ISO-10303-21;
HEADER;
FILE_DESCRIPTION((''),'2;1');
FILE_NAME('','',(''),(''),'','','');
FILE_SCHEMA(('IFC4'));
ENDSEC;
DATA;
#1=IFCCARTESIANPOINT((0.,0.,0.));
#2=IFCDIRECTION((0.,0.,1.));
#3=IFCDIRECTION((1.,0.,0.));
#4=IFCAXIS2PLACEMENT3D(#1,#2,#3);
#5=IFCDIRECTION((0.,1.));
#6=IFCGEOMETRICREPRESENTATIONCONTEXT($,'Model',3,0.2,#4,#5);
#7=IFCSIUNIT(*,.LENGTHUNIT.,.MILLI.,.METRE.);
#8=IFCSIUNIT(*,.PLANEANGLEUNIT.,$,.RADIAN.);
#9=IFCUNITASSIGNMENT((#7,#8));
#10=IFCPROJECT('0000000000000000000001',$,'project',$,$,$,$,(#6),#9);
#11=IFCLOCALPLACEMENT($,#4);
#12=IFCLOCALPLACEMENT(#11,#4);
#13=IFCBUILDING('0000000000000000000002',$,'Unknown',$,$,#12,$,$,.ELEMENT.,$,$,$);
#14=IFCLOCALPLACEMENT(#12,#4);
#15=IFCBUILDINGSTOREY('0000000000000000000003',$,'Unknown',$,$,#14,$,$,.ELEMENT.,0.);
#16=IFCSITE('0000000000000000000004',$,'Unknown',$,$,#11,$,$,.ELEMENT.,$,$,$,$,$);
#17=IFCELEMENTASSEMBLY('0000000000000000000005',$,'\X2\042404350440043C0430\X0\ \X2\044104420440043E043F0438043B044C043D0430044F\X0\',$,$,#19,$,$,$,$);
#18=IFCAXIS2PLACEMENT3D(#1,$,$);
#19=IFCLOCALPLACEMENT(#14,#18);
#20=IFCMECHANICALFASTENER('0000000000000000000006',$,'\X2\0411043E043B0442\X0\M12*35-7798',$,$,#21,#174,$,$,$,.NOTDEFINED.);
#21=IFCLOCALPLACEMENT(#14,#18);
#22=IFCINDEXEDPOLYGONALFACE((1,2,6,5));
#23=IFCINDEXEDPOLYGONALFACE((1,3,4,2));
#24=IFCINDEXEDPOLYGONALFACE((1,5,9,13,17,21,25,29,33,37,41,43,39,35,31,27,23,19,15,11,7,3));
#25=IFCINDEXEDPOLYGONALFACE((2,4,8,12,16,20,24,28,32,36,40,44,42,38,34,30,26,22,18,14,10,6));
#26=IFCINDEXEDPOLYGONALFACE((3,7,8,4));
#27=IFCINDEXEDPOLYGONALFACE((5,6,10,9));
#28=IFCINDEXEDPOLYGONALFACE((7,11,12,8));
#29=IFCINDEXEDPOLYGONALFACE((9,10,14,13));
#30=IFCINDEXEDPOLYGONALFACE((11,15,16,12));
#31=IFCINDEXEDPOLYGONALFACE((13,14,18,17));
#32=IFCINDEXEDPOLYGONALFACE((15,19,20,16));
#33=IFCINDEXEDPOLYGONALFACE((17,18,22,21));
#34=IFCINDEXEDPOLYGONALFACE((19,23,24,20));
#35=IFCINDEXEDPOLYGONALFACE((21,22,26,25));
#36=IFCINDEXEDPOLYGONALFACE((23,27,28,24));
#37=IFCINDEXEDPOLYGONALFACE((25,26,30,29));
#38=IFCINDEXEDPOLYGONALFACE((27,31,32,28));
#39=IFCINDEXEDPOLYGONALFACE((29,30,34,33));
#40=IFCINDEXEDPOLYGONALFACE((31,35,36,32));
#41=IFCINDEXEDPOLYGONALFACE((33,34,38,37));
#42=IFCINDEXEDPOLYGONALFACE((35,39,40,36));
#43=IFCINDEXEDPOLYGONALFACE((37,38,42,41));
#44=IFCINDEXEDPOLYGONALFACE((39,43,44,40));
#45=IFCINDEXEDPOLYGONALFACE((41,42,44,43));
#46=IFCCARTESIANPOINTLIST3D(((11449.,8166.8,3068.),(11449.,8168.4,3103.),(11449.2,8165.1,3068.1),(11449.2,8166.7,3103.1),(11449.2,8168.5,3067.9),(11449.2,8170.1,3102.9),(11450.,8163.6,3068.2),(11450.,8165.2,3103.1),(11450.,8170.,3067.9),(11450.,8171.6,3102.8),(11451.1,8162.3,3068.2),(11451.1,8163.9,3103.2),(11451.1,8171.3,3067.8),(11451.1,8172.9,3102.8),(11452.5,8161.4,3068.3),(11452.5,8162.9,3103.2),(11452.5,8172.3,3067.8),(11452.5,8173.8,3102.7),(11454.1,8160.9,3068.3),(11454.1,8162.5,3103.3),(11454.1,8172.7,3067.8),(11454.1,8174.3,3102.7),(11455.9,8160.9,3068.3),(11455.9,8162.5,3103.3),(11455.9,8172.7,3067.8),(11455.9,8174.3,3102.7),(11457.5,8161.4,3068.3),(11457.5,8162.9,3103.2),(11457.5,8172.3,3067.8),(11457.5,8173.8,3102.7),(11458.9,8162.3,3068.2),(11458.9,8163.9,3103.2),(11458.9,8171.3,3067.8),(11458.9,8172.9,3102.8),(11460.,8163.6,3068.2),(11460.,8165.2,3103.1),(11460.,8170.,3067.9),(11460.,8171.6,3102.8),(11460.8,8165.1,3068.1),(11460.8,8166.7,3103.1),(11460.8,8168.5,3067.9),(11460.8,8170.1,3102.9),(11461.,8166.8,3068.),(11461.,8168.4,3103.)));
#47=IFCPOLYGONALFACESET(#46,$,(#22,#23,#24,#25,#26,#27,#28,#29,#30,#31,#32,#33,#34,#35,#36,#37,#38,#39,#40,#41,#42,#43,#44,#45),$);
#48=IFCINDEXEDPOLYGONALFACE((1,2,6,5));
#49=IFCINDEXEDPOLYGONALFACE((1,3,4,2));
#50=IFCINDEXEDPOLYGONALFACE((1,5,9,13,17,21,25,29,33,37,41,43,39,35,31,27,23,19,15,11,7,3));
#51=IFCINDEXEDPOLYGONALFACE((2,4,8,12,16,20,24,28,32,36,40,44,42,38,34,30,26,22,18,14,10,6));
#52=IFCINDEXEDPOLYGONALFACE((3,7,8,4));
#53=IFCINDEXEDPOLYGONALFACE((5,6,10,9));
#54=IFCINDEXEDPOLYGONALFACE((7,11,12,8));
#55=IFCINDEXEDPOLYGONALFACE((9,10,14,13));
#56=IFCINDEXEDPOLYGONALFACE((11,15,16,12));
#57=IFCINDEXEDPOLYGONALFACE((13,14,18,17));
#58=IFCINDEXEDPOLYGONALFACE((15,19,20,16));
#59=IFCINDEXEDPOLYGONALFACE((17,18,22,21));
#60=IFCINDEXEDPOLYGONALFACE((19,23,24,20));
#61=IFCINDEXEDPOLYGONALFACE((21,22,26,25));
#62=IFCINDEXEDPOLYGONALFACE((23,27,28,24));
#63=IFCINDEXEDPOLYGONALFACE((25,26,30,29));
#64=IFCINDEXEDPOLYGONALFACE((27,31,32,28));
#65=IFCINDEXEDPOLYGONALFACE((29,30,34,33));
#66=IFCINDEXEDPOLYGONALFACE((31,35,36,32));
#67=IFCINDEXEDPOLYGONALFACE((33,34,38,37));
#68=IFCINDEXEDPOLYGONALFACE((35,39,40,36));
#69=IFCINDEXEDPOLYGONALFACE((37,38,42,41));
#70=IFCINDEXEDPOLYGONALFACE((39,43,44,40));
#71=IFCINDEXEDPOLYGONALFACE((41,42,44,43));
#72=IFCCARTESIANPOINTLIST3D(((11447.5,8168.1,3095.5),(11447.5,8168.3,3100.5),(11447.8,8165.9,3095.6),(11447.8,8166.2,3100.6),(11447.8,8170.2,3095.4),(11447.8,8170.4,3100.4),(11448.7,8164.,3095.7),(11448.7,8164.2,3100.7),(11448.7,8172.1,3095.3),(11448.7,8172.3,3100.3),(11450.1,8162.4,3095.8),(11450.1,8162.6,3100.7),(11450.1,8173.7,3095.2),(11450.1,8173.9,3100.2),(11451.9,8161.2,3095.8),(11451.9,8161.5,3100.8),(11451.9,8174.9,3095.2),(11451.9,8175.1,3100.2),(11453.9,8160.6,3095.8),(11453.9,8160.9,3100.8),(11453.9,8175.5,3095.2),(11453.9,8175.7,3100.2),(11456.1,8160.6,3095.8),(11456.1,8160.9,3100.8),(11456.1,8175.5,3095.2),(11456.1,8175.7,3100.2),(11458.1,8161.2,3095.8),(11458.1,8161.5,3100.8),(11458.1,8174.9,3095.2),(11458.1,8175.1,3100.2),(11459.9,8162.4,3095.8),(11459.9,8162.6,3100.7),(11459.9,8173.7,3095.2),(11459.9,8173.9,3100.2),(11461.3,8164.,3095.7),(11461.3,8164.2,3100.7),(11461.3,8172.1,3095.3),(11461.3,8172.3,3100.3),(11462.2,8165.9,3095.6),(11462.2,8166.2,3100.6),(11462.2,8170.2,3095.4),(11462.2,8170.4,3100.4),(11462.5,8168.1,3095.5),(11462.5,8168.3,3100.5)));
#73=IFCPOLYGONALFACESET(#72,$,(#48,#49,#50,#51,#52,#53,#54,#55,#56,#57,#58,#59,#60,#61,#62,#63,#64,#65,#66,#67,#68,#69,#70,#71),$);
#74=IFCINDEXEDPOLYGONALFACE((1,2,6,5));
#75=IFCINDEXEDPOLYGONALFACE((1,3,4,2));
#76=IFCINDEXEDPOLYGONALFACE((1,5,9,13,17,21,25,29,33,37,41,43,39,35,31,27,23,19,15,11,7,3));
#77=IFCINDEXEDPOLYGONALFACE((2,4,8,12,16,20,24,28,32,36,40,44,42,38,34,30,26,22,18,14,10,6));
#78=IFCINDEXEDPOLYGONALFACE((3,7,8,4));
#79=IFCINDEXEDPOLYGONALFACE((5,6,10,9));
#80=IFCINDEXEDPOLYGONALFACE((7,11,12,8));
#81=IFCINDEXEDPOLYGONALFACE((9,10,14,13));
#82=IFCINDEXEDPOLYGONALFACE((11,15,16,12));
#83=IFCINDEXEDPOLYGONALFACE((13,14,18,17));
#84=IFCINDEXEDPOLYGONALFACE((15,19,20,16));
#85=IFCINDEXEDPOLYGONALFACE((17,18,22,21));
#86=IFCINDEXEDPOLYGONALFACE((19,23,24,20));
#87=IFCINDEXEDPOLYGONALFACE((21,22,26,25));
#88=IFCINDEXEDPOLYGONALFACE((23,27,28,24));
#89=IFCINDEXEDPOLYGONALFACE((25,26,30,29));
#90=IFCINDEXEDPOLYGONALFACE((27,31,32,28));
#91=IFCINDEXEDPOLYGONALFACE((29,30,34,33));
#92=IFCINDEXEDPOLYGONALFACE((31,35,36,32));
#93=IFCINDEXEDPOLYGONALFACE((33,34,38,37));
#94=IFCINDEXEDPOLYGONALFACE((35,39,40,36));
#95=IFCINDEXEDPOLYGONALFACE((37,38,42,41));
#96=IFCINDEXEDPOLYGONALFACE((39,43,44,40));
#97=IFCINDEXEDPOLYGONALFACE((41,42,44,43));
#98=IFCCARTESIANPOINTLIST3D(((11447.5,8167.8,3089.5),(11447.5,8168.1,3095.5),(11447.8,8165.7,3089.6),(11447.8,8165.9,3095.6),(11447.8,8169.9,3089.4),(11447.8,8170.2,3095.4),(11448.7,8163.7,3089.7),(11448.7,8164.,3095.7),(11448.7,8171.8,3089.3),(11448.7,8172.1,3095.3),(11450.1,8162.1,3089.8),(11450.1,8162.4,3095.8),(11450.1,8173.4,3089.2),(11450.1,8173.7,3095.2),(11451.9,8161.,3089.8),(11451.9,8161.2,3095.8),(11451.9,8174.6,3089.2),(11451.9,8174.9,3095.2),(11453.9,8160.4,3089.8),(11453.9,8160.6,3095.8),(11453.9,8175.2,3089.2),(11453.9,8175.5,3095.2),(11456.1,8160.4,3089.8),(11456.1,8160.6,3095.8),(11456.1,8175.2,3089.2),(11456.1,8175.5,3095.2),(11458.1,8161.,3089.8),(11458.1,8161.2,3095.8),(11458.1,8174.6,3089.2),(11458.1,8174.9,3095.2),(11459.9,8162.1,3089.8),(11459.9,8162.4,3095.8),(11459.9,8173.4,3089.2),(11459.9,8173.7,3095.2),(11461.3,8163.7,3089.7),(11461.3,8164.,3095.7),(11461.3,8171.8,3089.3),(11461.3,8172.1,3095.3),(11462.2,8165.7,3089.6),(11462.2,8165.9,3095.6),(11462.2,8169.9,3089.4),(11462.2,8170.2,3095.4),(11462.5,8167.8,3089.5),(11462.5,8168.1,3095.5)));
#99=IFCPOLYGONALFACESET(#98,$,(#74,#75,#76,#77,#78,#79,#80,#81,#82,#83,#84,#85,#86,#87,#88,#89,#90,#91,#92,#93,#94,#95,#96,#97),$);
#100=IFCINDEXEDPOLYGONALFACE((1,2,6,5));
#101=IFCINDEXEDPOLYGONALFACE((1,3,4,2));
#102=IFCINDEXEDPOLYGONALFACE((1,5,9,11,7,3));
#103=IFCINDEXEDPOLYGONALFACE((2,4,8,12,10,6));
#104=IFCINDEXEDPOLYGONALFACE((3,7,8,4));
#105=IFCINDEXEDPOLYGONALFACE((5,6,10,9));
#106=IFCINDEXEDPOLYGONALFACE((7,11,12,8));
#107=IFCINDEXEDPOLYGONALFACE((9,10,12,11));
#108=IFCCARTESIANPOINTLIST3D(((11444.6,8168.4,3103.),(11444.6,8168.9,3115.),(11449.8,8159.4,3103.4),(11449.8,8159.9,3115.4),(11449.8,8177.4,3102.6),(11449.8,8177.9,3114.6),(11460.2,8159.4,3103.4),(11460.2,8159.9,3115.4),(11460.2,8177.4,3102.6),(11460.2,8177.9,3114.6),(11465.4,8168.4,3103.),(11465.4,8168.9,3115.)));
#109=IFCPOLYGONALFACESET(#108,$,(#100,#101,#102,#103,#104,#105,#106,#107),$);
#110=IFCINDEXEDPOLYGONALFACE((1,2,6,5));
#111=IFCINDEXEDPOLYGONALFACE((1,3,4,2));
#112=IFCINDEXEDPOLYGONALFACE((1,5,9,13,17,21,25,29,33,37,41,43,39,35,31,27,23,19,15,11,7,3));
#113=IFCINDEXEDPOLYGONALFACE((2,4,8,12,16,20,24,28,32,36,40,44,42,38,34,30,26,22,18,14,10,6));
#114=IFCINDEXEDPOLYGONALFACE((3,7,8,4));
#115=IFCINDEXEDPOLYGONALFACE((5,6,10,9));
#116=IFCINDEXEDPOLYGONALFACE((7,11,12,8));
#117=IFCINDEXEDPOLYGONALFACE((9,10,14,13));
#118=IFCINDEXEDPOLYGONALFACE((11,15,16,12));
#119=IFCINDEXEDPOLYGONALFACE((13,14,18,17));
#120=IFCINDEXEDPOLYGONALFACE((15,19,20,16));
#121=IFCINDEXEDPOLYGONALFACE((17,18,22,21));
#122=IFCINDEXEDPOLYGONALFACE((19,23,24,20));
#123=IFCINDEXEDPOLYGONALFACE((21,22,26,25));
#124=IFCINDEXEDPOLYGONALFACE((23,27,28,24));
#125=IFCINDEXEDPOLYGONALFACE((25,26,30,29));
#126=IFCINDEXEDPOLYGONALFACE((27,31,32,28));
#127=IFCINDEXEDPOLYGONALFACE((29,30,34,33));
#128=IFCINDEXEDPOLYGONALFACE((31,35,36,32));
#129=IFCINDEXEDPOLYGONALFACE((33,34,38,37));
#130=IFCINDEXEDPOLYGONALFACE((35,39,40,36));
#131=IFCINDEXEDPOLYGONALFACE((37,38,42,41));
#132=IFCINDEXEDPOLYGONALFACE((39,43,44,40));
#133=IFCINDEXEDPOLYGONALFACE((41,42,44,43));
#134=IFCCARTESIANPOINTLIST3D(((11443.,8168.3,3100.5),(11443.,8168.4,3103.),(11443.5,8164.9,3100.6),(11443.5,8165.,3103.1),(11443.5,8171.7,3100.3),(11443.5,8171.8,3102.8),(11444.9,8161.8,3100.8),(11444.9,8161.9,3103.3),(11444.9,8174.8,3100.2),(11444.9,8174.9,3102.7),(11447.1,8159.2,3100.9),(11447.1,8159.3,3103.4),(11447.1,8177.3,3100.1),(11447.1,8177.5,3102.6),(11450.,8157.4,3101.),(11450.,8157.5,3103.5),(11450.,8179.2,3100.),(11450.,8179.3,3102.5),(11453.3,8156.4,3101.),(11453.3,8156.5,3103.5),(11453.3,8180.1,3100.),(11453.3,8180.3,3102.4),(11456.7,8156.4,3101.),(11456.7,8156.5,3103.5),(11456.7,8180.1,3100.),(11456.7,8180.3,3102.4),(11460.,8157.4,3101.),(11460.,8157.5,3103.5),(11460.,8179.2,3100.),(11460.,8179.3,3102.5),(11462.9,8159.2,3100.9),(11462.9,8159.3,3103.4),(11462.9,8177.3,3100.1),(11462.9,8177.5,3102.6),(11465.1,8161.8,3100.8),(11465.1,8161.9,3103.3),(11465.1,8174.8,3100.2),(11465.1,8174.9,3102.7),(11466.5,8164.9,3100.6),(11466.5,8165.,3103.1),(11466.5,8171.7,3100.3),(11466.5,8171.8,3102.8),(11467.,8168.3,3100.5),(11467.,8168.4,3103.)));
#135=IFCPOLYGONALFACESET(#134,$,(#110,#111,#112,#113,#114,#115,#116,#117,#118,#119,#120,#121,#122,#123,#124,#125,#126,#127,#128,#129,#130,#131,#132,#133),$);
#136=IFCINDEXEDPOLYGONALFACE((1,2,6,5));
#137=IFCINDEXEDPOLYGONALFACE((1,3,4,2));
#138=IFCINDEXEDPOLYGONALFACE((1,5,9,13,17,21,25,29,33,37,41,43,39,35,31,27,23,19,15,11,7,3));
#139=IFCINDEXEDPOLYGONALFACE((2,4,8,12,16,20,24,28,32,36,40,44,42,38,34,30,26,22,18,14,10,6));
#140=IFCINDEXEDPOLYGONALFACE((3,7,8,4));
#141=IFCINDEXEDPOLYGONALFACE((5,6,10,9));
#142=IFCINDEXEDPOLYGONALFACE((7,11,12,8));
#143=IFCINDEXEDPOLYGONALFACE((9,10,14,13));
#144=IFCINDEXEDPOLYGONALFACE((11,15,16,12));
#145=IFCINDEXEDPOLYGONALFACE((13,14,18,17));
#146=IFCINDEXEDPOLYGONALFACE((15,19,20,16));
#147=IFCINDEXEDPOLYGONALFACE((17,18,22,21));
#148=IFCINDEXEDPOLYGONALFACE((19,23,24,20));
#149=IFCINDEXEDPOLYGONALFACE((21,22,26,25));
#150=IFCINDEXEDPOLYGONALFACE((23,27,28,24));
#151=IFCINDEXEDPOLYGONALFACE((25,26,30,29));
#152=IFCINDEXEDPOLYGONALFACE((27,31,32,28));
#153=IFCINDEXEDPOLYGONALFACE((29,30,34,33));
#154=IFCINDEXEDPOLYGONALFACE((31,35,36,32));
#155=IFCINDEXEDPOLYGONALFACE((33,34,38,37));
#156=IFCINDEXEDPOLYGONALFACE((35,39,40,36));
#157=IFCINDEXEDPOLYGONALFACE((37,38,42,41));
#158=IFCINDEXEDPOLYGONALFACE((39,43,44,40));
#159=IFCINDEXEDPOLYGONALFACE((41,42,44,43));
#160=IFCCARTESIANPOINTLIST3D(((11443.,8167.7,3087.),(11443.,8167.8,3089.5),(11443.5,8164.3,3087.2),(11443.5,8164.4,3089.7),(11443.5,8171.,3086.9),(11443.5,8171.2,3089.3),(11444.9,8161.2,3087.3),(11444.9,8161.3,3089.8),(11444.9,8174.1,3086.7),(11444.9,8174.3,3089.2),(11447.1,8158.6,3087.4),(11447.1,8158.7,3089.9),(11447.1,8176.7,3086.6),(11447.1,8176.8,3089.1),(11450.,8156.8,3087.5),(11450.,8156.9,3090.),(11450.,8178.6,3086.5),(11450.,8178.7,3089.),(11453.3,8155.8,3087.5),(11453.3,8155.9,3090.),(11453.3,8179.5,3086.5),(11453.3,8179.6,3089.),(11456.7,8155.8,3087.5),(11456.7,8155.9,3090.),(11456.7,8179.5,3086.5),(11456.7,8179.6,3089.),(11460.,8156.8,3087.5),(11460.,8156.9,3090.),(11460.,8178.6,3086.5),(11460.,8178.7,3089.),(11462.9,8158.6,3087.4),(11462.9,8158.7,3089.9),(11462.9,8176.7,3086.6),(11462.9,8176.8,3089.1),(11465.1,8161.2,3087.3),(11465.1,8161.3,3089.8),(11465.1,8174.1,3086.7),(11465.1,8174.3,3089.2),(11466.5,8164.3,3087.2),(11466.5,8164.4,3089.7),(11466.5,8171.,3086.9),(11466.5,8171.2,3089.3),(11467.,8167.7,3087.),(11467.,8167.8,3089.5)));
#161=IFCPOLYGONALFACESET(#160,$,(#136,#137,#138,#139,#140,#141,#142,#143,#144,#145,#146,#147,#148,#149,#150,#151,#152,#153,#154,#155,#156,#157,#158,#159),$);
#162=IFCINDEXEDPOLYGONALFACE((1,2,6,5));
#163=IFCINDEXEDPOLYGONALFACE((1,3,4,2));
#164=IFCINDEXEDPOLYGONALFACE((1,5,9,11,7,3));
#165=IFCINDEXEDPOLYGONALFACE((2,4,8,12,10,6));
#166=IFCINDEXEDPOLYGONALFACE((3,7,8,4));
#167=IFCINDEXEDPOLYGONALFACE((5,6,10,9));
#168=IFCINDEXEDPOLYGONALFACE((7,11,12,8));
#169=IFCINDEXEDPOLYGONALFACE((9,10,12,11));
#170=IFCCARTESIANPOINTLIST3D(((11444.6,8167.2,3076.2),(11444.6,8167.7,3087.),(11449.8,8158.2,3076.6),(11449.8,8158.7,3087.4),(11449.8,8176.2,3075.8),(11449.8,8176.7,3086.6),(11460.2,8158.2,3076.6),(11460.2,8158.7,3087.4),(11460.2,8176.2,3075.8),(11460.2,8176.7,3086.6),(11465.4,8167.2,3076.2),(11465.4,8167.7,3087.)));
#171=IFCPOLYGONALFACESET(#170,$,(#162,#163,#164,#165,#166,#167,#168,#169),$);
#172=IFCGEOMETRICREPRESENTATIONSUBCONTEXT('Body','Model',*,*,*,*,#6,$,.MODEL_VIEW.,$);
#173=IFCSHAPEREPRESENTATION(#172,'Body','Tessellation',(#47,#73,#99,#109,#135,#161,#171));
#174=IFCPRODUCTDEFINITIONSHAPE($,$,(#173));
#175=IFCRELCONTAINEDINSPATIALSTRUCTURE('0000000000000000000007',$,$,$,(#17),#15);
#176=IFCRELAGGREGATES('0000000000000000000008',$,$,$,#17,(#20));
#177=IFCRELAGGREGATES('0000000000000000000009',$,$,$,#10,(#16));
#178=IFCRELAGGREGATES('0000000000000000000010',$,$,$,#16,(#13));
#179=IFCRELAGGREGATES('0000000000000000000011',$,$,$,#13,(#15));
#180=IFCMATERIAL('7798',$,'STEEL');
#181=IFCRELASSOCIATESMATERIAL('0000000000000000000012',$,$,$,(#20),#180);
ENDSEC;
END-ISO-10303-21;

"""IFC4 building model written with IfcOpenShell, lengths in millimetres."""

from ifc_helpers import new_model, si_unit, direction, frame, origin_with_axes, place, context, subcontext, project, spatial, line, arc, indexed_curve, outline, extrude, source, transform, mapped, material, element, aggregate, save


model = new_model("IFC4")

# Units and contexts
model_context = context("Model", 3, precision=0.2, world=origin_with_axes(), true_north=direction((0.0, 1.0)))
body_context = subcontext(model_context, "Body", "Model", "MODEL_VIEW")
ifc_project = project(units=[si_unit("LENGTHUNIT", "METRE", prefix="MILLI"), si_unit("PLANEANGLEUNIT", "RADIAN")], contexts=[model_context])

# Site, building, storey
site_placement = place(None, origin_with_axes())
site = spatial("IfcSite", under=ifc_project, at=site_placement, Name="Unknown", CompositionType="ELEMENT")
building_placement = place(site_placement, origin_with_axes())
building = spatial("IfcBuilding", under=site, at=building_placement, Name="Unknown", CompositionType="ELEMENT")
storey_placement = place(building_placement, origin_with_axes())
storey = spatial("IfcBuildingStorey", under=building, at=storey_placement, Name="Unknown", CompositionType="ELEMENT", Elevation=0.0)

# Element assembly
assembly_1_placement = place(storey_placement, frame((11400.0, 88.6, 3426.7), z_axis=(1.0, 0.0, 0.0), x_axis=(0.0, 0.998969, -0.045408)))
assembly_1 = element("IfcElementAssembly", 1, at=assembly_1_placement, inside=storey, Name="Ферма стропильная")

# Mechanical fastener
ifc_material_1 = material(Name="7798", Category="STEEL")
shared_shape_1 = source(origin_with_axes(), body_context, "Body", "SweptSolid", [
    extrude(outline(indexed_curve([(6.0, 0.0), (0.0, 6.0), (-6.0, 0.0), (0.0, -6.0)], segments=[arc(1, 2, 3), arc(3, 4, 1)])), frame((0.0, 0.0, 7.5), z_axis=(0.0, 0.0, -1.0), x_axis=(0.0, 1.0, 0.0)), (0.0, 0.0, 1.0), 35.0),
    extrude(outline(indexed_curve([(7.5, 0.0), (0.0, 7.5), (-7.5, 0.0), (0.0, -7.5)], segments=[arc(1, 2, 3), arc(3, 4, 1)])), frame((0.0, 0.0, 5.0), z_axis=(0.0, 0.0, -1.0), x_axis=(0.0, 1.0, 0.0)), (0.0, 0.0, 1.0), 5.0),
    extrude(outline(indexed_curve([(7.5, 0.0), (0.0, 7.5), (-7.5, 0.0), (0.0, -7.5)], segments=[arc(1, 2, 3), arc(3, 4, 1)])), frame((0.0, 0.0, 0.0), z_axis=(0.0, 0.0, -1.0), x_axis=(0.0, 1.0, 0.0)), (0.0, 0.0, 1.0), 6.0),
    extrude(outline(indexed_curve([(10.4, 0.0), (5.2, 9.0), (-5.2, 9.0), (-10.4, 0.0), (-5.2, -9.0), (5.2, -9.0)], segments=[line(1, 2, 3, 4, 5, 6, 1)])), frame((0.0, 0.0, 19.5), z_axis=(0.0, 0.0, -1.0), x_axis=(0.0, 1.0, 0.0)), (0.0, 0.0, 1.0), 12.0),
    extrude(outline(indexed_curve([(12.0, 0.0), (0.0, 12.0), (-12.0, 0.0), (0.0, -12.0)], segments=[arc(1, 2, 3), arc(3, 4, 1)])), frame((0.0, 0.0, 7.5), z_axis=(0.0, 0.0, -1.0), x_axis=(0.0, 1.0, 0.0)), (0.0, 0.0, 1.0), 2.5),
    extrude(outline(indexed_curve([(12.0, 0.0), (0.0, 12.0), (-12.0, 0.0), (0.0, -12.0)], segments=[arc(1, 2, 3), arc(3, 4, 1)])), frame((0.0, 0.0, -6.0), z_axis=(0.0, 0.0, -1.0), x_axis=(0.0, 1.0, 0.0)), (0.0, 0.0, 1.0), 2.5),
    extrude(outline(indexed_curve([(10.4, 0.0), (5.2, 9.0), (-5.2, 9.0), (-10.4, 0.0), (-5.2, -9.0), (5.2, -9.0)], segments=[line(1, 2, 3, 4, 5, 6, 1)])), frame((0.0, 0.0, -8.5), z_axis=(0.0, 0.0, -1.0), x_axis=(0.0, 1.0, 0.0)), (0.0, 0.0, 1.0), 10.8),
])
mechanical_fastener_1_placement = place(assembly_1_placement, frame((8086.1, 36.0, 55.0), z_axis=(0.0, 1.0, 0.0), x_axis=(1.0, 0.0, 0.0)))
mechanical_fastener_1 = element("IfcMechanicalFastener", 2, at=mechanical_fastener_1_placement, material=ifc_material_1, Name="БолтM12*35-7798", PredefinedType="NOTDEFINED", context=body_context, shape_type="MappedRepresentation", body=[
    mapped(shared_shape_1, transform((0.0, 0.0, 0.0))),
])
aggregate(assembly_1, [mechanical_fastener_1])

save(model, "model.ifc")
